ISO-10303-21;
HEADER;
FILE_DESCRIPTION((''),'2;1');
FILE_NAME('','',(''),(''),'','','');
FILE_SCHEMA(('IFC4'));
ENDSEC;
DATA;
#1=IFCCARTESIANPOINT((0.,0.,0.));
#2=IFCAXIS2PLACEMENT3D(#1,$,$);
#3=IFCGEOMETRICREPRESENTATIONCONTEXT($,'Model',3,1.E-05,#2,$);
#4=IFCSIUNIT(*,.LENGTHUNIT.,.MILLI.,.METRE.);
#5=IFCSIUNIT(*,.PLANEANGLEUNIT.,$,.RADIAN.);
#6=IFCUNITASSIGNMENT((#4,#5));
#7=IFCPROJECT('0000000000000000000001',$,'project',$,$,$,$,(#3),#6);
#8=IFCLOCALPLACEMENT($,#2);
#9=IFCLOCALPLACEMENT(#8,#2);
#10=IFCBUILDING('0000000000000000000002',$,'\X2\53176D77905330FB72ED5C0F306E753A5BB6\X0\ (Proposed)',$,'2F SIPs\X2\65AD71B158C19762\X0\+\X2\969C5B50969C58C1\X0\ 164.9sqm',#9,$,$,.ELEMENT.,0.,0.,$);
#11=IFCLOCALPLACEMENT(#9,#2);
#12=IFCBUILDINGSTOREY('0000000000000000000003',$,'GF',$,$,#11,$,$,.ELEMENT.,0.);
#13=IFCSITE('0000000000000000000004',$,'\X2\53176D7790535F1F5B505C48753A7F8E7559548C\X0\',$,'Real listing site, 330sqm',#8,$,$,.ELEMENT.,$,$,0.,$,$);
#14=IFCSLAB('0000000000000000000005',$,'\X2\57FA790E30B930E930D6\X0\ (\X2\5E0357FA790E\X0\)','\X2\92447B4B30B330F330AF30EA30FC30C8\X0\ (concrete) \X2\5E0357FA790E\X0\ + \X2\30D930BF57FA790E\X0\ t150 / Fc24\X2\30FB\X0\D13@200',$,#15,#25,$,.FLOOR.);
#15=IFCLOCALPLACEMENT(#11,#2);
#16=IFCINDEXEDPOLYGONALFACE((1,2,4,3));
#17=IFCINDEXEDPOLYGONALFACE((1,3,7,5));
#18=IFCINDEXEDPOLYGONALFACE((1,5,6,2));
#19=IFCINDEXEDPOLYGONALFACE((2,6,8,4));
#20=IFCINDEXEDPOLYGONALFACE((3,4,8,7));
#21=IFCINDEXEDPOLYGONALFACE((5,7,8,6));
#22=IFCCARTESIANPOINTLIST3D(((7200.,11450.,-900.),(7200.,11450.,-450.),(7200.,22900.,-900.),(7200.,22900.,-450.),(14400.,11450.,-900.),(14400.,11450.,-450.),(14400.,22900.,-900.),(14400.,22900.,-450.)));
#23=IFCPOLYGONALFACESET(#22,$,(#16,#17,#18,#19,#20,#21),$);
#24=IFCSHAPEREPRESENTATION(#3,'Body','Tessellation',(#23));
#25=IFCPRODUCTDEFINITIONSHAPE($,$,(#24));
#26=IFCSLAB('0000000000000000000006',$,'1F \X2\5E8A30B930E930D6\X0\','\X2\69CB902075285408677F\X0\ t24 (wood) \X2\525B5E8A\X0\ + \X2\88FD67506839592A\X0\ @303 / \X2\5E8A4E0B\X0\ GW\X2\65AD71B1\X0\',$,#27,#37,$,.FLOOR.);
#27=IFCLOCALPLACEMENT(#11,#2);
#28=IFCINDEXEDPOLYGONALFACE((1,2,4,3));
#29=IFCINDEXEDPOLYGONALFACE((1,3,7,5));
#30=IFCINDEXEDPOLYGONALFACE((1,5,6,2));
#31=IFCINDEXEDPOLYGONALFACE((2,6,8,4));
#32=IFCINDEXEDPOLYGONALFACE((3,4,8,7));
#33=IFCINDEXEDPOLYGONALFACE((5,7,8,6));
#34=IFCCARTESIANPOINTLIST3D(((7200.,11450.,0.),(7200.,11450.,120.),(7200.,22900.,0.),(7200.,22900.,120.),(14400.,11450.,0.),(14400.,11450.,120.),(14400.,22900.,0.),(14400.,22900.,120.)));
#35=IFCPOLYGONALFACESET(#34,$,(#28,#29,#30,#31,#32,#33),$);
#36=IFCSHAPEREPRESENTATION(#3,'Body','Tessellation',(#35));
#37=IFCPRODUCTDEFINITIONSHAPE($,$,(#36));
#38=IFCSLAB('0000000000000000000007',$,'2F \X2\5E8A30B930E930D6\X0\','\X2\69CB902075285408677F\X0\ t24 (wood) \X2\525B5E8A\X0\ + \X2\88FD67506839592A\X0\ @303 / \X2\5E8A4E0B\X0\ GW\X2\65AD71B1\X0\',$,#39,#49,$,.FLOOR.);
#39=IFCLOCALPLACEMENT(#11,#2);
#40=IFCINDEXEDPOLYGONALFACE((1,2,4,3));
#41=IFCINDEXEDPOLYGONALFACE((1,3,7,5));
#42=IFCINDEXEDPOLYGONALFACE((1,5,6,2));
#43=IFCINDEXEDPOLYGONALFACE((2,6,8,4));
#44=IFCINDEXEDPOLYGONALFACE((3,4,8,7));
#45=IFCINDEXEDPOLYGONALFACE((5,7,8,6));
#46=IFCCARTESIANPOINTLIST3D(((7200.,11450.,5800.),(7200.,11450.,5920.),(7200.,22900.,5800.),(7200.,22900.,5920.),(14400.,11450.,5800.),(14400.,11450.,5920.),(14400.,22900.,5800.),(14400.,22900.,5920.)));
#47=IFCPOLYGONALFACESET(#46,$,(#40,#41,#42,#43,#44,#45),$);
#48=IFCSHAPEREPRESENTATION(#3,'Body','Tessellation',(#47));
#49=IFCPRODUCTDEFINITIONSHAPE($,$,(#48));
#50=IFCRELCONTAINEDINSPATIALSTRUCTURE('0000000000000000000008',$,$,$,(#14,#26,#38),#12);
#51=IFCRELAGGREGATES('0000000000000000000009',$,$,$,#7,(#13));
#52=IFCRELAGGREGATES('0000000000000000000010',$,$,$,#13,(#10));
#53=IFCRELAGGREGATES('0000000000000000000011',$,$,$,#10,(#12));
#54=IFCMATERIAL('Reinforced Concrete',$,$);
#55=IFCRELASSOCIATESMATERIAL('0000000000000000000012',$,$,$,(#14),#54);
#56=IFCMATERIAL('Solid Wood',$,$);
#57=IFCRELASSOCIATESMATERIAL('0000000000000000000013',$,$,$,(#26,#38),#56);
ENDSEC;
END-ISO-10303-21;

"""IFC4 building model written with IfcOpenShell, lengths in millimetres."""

from ifc_helpers import new_model, si_unit, frame, frame_2d, origin, place, context, project, spatial, rectangle, extrude, material, element, save


model = new_model("IFC4")

# Units and contexts
model_context = context("Model", 3, precision=1e-05, world=origin())
ifc_project = project(units=[si_unit("LENGTHUNIT", "METRE", prefix="MILLI"), si_unit("PLANEANGLEUNIT", "RADIAN")], contexts=[model_context])

# Site, building, storey
site_placement = place(None, origin())
site = spatial("IfcSite", under=ifc_project, at=site_placement, Name="北海道弟子屈町美留和", ObjectType="Real listing site, 330sqm", CompositionType="ELEMENT", RefElevation=0.0)
building_placement = place(site_placement, origin())
building = spatial("IfcBuilding", under=site, at=building_placement, Name="北海道・狭小の町家 (Proposed)", ObjectType="2F SIPs断熱壁面+障子障壁 164.9sqm", CompositionType="ELEMENT", ElevationOfRefHeight=0.0, ElevationOfTerrain=0.0)
storey_placement = place(building_placement, origin())
storey = spatial("IfcBuildingStorey", under=building, at=storey_placement, Name="GF", CompositionType="ELEMENT", Elevation=0.0)

# Shared definitions
ifc_material_1 = material(Name="Solid Wood")

# Slabs
ifc_material_2 = material(Name="Reinforced Concrete")
slab_1_placement = place(storey_placement, frame((3600.0, 5725.0, -450.0)))
element("IfcSlab", 1, at=slab_1_placement, inside=storey, material=ifc_material_2, Name="基礎スラブ (布基礎)", Description="鉄筋コンクリート (concrete) 布基礎 + ベタ基礎 t150 / Fc24・D13@200", PredefinedType="FLOOR", context=model_context, shape_type="SweptSolid", body=[
    extrude(rectangle(XDim=7200.0, YDim=11450.0, at=frame_2d((3600.0, 5725.0))), frame((3600.0, 5725.0, -450.0)), (0.0, 0.0, 1.0), 450.0),
])
slab_2_placement = place(storey_placement, frame((3600.0, 5725.0, 0.0)))
element("IfcSlab", 2, at=slab_2_placement, inside=storey, material=ifc_material_1, Name="1F 床スラブ", Description="構造用合板 t24 (wood) 剛床 + 製材根太 @303 / 床下 GW断熱", PredefinedType="FLOOR", context=model_context, shape_type="SweptSolid", body=[
    extrude(rectangle(XDim=7200.0, YDim=11450.0, at=frame_2d((3600.0, 5725.0))), frame((3600.0, 5725.0, 0.0)), (0.0, 0.0, 1.0), 120.0),
])
slab_3_placement = place(storey_placement, frame((3600.0, 5725.0, 2900.0)))
element("IfcSlab", 3, at=slab_3_placement, inside=storey, material=ifc_material_1, Name="2F 床スラブ", Description="構造用合板 t24 (wood) 剛床 + 製材根太 @303 / 床下 GW断熱", PredefinedType="FLOOR", context=model_context, shape_type="SweptSolid", body=[
    extrude(rectangle(XDim=7200.0, YDim=11450.0, at=frame_2d((3600.0, 5725.0))), frame((3600.0, 5725.0, 2900.0)), (0.0, 0.0, 1.0), 120.0),
])

save(model, "model.ifc")
